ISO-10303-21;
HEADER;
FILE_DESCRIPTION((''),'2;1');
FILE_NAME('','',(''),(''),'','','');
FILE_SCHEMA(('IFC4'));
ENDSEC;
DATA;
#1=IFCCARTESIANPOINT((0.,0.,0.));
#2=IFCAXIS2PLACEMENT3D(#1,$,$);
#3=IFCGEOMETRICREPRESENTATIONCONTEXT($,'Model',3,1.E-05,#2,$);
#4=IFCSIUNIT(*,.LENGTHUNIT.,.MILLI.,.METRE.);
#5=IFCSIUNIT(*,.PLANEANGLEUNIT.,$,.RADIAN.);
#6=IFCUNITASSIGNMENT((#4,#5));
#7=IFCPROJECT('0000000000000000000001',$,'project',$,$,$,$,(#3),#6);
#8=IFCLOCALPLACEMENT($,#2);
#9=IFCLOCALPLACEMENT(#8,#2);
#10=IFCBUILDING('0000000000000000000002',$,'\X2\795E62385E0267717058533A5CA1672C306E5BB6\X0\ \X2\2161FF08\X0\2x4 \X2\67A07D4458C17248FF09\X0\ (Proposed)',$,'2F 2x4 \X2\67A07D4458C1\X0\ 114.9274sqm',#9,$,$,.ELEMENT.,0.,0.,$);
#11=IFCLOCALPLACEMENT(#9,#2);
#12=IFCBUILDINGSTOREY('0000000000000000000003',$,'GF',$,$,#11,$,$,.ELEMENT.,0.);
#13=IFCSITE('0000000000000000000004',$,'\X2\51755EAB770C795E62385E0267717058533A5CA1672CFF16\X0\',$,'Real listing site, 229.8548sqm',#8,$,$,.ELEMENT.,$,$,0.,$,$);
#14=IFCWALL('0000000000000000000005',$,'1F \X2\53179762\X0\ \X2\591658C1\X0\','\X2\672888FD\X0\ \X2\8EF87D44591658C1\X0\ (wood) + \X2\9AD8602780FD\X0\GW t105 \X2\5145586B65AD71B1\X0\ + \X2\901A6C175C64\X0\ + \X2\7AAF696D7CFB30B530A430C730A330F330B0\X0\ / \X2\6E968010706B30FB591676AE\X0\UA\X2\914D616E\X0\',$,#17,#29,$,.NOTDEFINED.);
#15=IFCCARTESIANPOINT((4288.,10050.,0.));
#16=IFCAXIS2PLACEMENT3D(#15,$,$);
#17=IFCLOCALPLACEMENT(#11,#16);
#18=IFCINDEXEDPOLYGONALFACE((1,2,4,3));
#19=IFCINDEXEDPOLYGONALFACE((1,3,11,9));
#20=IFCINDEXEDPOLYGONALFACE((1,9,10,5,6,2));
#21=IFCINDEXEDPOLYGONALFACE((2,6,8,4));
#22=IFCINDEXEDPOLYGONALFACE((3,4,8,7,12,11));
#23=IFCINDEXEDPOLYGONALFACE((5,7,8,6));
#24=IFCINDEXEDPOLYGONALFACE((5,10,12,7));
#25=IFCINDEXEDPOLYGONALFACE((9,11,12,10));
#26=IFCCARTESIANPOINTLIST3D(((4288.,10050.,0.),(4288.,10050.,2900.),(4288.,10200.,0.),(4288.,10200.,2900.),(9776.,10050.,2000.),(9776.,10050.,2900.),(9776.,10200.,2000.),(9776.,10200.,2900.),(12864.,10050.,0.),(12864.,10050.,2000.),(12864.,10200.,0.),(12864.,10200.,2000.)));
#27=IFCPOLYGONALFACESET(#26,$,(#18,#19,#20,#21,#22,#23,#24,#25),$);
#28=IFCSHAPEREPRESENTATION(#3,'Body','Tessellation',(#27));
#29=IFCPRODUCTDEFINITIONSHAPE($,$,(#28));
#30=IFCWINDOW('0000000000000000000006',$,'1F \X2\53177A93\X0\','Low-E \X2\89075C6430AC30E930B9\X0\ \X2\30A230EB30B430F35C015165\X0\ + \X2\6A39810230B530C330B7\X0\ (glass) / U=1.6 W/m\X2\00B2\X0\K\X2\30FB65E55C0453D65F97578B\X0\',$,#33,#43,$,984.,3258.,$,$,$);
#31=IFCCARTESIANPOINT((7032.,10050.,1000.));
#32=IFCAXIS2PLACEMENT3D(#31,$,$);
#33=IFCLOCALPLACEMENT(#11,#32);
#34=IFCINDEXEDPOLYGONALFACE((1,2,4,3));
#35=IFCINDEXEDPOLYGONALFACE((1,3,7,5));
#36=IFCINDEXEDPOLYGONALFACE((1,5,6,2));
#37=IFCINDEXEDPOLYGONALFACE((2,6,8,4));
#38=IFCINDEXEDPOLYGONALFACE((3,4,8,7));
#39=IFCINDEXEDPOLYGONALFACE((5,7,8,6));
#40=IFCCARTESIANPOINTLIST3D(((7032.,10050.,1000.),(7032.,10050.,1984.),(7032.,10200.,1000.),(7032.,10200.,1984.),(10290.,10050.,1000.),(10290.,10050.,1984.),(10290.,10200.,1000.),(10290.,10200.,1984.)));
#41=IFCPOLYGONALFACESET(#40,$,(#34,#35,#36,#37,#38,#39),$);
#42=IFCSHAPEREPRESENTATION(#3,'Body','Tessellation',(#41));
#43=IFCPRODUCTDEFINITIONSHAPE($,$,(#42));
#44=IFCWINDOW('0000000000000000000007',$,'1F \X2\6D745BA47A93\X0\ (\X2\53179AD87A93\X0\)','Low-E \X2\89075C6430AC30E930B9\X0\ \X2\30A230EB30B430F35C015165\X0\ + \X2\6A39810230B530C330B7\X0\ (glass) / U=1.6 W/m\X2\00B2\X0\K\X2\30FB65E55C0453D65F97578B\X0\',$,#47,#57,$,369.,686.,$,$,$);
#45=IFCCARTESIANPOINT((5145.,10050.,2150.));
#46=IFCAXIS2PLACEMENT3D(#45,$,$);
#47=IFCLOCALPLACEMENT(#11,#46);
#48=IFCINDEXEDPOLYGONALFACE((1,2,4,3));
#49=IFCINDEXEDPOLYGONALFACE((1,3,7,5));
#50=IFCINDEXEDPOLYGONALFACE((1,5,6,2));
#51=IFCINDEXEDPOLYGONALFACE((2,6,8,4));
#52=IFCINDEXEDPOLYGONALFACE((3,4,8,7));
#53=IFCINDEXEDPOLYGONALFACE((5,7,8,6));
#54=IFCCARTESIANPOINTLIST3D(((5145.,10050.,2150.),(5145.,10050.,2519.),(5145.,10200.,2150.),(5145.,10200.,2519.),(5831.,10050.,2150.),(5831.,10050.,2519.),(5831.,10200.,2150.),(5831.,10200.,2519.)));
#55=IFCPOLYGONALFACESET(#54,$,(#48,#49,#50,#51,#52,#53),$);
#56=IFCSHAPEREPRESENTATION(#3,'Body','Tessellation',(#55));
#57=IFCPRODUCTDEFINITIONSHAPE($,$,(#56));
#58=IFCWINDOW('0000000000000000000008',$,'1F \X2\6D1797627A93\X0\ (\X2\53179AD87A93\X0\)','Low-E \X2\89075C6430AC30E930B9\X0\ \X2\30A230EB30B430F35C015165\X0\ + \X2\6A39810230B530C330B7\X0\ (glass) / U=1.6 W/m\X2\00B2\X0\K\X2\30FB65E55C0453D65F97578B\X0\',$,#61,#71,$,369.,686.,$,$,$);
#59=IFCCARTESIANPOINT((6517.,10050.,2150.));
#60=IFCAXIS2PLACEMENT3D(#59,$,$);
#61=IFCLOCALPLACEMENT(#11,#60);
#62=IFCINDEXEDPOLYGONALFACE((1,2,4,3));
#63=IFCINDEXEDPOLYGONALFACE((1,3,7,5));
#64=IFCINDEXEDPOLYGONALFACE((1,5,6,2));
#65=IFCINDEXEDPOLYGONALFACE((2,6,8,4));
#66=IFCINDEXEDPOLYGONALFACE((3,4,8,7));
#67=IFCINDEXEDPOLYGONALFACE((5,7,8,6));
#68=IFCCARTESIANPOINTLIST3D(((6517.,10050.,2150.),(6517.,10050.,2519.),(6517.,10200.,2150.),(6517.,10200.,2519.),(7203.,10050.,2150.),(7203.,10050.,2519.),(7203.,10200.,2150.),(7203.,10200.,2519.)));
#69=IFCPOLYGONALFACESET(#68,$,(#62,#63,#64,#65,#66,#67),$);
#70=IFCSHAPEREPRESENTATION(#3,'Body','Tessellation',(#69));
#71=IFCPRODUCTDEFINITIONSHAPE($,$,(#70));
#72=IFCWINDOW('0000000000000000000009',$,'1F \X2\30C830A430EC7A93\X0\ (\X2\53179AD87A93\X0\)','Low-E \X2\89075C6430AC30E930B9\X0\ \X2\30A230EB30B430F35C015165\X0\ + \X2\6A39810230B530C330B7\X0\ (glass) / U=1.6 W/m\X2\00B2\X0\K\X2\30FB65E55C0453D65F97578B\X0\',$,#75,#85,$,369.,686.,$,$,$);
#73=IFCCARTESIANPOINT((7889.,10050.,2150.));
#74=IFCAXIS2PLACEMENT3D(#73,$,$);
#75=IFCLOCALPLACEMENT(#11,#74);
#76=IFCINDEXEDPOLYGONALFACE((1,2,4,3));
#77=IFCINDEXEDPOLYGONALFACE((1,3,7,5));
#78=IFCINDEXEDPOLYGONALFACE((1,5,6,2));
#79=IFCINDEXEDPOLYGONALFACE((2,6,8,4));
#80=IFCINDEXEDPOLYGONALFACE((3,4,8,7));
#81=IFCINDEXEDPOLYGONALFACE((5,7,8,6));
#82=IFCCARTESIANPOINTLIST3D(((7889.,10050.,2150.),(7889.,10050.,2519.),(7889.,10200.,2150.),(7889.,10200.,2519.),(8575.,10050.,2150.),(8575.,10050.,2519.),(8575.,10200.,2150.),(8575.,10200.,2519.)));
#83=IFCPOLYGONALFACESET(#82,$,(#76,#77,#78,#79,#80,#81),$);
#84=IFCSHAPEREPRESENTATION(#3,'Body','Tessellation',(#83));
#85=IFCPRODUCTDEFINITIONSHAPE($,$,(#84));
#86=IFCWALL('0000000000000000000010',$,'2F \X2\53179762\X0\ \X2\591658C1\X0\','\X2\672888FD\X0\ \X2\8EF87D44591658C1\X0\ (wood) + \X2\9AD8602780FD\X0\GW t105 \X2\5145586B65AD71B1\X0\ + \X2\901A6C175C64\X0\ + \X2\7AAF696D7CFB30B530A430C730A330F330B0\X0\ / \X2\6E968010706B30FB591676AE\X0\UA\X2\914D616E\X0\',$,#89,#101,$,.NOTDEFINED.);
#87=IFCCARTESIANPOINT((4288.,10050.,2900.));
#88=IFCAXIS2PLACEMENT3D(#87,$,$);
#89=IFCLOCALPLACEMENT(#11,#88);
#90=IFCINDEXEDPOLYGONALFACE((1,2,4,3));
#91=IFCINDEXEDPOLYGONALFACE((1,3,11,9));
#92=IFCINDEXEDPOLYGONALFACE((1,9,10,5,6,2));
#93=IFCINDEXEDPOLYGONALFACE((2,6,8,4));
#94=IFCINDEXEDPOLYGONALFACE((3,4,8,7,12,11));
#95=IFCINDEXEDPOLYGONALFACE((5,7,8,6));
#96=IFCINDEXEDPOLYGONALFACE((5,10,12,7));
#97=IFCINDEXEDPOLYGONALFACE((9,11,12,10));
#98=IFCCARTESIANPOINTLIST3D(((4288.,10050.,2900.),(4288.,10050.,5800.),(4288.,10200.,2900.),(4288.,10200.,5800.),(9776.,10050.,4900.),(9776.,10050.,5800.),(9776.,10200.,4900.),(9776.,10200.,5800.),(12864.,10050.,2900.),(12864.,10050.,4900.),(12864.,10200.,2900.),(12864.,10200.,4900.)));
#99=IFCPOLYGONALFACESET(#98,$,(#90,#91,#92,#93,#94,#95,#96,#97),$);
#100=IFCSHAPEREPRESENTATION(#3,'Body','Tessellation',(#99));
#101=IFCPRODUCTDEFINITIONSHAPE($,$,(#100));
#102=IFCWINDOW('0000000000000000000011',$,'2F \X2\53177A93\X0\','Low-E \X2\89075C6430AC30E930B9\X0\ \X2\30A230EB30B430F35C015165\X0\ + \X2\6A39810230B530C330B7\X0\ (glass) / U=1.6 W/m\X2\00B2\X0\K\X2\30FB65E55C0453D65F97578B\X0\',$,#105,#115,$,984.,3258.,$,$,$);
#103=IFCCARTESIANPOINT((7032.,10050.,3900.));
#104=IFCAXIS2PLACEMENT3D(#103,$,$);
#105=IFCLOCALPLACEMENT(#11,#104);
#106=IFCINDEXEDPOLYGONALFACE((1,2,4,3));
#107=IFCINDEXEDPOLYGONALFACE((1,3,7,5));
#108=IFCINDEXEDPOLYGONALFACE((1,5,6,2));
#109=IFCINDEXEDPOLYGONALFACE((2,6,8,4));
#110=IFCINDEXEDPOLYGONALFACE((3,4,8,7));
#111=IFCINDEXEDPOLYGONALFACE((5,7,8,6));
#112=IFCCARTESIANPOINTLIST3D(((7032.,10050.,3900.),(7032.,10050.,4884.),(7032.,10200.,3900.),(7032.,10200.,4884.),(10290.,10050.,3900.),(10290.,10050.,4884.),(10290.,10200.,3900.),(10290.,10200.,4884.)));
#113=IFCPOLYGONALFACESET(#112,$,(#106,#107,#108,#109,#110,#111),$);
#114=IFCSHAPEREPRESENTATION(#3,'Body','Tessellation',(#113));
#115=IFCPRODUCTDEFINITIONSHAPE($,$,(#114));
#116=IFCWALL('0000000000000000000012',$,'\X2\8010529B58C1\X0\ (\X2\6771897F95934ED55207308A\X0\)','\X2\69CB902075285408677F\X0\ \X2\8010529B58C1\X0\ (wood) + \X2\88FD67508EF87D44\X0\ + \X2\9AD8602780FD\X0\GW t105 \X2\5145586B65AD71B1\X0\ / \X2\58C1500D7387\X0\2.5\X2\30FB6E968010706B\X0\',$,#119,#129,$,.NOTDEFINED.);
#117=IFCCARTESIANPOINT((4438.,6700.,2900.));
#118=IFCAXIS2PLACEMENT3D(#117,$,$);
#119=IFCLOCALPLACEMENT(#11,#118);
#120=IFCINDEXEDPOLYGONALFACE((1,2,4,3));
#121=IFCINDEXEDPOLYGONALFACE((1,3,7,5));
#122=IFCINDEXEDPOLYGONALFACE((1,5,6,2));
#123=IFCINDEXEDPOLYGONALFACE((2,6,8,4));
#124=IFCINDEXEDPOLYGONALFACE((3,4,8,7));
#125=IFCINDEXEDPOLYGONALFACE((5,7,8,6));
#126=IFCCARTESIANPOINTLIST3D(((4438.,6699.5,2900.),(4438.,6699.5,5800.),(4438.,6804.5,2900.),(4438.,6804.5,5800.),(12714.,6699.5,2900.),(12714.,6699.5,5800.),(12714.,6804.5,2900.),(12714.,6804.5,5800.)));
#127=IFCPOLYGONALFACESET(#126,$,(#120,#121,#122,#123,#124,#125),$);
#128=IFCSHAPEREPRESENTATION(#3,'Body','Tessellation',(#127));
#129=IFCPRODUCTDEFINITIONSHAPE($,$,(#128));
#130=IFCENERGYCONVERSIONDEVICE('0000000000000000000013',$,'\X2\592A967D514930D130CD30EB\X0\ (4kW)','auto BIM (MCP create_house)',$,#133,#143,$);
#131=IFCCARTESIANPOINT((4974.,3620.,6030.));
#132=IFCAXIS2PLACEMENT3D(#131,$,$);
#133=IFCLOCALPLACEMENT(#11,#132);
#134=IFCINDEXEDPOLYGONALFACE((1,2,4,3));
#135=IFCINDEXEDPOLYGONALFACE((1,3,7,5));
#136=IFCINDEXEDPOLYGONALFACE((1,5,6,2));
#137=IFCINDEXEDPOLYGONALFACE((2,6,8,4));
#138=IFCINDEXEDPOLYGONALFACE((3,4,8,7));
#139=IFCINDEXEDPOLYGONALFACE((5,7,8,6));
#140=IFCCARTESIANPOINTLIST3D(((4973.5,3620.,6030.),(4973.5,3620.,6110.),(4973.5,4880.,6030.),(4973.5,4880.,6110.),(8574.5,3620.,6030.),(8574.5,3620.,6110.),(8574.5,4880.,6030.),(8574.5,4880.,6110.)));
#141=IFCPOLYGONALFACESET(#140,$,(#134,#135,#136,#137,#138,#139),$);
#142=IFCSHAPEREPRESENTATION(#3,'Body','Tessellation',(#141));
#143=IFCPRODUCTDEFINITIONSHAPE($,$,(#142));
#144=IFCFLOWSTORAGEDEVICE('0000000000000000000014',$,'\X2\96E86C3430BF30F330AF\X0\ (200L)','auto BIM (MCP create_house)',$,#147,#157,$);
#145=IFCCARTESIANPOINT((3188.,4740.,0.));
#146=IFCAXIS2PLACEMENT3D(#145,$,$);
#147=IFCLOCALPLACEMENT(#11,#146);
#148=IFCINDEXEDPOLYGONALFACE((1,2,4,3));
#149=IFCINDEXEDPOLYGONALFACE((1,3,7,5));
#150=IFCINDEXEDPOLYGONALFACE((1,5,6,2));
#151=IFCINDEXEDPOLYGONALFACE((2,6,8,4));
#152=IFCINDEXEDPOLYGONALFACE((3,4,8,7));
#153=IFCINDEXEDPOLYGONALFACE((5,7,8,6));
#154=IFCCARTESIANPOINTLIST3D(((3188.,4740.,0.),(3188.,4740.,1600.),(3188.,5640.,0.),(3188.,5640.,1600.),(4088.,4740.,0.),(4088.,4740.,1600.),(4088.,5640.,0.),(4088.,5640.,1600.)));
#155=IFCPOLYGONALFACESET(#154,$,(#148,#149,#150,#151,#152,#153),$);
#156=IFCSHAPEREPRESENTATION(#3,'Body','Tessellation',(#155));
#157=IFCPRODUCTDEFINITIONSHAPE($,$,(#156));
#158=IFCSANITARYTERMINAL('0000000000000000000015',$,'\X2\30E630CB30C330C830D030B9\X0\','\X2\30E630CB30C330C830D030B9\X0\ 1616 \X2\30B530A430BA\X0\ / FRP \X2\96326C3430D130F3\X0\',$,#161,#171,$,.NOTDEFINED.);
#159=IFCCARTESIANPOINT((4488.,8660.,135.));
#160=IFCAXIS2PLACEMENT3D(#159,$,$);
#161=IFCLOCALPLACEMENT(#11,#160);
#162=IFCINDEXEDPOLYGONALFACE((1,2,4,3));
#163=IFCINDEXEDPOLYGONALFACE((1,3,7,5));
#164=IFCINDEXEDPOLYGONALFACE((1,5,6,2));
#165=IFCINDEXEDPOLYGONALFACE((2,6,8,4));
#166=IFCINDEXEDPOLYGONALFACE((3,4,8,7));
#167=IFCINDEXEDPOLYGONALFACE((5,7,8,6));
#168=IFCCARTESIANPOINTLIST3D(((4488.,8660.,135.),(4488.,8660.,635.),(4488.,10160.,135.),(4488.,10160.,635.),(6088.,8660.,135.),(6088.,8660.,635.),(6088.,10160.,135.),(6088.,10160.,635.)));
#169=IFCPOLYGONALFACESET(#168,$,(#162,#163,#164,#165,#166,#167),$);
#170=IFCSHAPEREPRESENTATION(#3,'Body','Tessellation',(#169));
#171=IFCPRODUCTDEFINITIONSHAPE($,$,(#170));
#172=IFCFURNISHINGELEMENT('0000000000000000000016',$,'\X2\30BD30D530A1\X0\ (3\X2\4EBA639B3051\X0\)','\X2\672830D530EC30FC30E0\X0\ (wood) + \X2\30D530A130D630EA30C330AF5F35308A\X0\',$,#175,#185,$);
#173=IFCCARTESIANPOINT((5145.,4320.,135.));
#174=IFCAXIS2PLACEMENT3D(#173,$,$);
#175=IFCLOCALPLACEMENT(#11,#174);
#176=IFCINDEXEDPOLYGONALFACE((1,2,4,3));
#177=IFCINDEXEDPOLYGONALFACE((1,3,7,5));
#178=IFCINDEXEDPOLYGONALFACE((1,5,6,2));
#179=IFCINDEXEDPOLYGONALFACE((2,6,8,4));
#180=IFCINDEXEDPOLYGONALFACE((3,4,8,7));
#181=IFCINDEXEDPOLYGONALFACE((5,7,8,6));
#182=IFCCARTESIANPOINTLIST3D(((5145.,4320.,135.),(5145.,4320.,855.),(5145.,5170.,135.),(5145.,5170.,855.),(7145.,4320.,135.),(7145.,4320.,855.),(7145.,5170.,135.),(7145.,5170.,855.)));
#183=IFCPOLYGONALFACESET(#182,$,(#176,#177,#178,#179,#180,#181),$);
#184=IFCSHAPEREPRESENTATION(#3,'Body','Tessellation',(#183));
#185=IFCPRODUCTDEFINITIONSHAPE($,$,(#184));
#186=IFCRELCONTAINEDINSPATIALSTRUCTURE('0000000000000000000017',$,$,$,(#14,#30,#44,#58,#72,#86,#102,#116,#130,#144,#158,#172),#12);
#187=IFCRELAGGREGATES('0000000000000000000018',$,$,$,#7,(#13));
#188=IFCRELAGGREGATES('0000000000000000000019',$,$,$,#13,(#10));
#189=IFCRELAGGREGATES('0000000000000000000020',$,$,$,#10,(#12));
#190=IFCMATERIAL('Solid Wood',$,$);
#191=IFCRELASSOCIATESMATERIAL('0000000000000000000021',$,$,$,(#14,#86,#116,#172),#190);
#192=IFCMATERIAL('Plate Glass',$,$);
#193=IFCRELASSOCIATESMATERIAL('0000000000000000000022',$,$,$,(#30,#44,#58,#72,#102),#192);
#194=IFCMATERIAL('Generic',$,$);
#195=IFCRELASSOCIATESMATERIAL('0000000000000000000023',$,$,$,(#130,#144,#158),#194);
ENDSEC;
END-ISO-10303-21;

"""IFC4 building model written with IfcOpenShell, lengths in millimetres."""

from ifc_helpers import new_model, si_unit, frame, frame_2d, origin, place, context, project, spatial, rectangle, extrude, material, element, fill, save


model = new_model("IFC4")

# Units and contexts
model_context = context("Model", 3, precision=1e-05, world=origin())
ifc_project = project(units=[si_unit("LENGTHUNIT", "METRE", prefix="MILLI"), si_unit("PLANEANGLEUNIT", "RADIAN")], contexts=[model_context])

# Site, building, storey
site_placement = place(None, origin())
site = spatial("IfcSite", under=ifc_project, at=site_placement, Name="兵庫県神戸市東灘区岡本６", ObjectType="Real listing site, 229.8548sqm", CompositionType="ELEMENT", RefElevation=0.0)
building_placement = place(site_placement, origin())
building = spatial("IfcBuilding", under=site, at=building_placement, Name="神戸市東灘区岡本の家 Ⅱ（2x4 枠組壁版） (Proposed)", ObjectType="2F 2x4 枠組壁 114.9274sqm", CompositionType="ELEMENT", ElevationOfRefHeight=0.0, ElevationOfTerrain=0.0)
storey_placement = place(building_placement, origin())
storey = spatial("IfcBuildingStorey", under=building, at=storey_placement, Name="GF", CompositionType="ELEMENT", Elevation=0.0)

# Wall, openings, windows
ifc_material_1 = material(Name="Solid Wood")
wall_1_placement = place(storey_placement, frame((4288.0, 10050.0, 0.0)))
wall_1 = element("IfcWall", 1, at=wall_1_placement, inside=storey, material=ifc_material_1, Name="1F 北面 外壁", Description="木製 軸組外壁 (wood) + 高性能GW t105 充填断熱 + 通気層 + 窯業系サイディング / 準耐火・外皮UA配慮", PredefinedType="NOTDEFINED", context=model_context, shape_type="SweptSolid", body=[
    extrude(rectangle(XDim=8576.0, YDim=150.0, at=frame_2d((4288.0, 75.0))), frame((4288.0, 10050.0, 0.0)), (0.0, 0.0, 1.0), 2900.0),
])
opening_1_placement = place(storey_placement, frame((7032.0, 10050.0, 1000.0)))
opening_1 = element("IfcOpeningElement", 2, at=opening_1_placement, cuts=wall_1, PredefinedType="NOTDEFINED", context=model_context, shape_type="SweptSolid", body=[
    extrude(rectangle(XDim=3258.0, YDim=150.0, at=frame_2d((1629.0, 75.0))), frame((7032.0, 10050.0, 1000.0)), (0.0, 0.0, 1.0), 984.0),
])
opening_2_placement = place(storey_placement, frame((5145.0, 10050.0, 2150.0)))
opening_2 = element("IfcOpeningElement", 3, at=opening_2_placement, cuts=wall_1, PredefinedType="NOTDEFINED", context=model_context, shape_type="SweptSolid", body=[
    extrude(rectangle(XDim=686.0, YDim=150.0, at=frame_2d((343.0, 75.0))), frame((5145.0, 10050.0, 2150.0)), (0.0, 0.0, 1.0), 369.0),
])
opening_3_placement = place(storey_placement, frame((6517.0, 10050.0, 2150.0)))
opening_3 = element("IfcOpeningElement", 4, at=opening_3_placement, cuts=wall_1, PredefinedType="NOTDEFINED", context=model_context, shape_type="SweptSolid", body=[
    extrude(rectangle(XDim=686.0, YDim=150.0, at=frame_2d((343.0, 75.0))), frame((6517.0, 10050.0, 2150.0)), (0.0, 0.0, 1.0), 369.0),
])
opening_4_placement = place(storey_placement, frame((7889.0, 10050.0, 2150.0)))
opening_4 = element("IfcOpeningElement", 5, at=opening_4_placement, cuts=wall_1, PredefinedType="NOTDEFINED", context=model_context, shape_type="SweptSolid", body=[
    extrude(rectangle(XDim=686.0, YDim=150.0, at=frame_2d((343.0, 75.0))), frame((7889.0, 10050.0, 2150.0)), (0.0, 0.0, 1.0), 369.0),
])
ifc_material_2 = material(Name="Plate Glass")
window_1_placement = place(storey_placement, frame((7032.0, 10050.0, 1000.0)))
window_1 = element("IfcWindow", 6, at=window_1_placement, inside=storey, material=ifc_material_2, Name="1F 北窓", Description="Low-E 複層ガラス アルゴン封入 + 樹脂サッシ (glass) / U=1.6 W/m²K・日射取得型", OverallHeight=984.0, OverallWidth=3258.0, context=model_context, shape_type="SweptSolid", body=[
    extrude(rectangle(XDim=3258.0, YDim=150.0, at=frame_2d((1629.0, 75.0))), frame((7032.0, 10050.0, 1000.0)), (0.0, 0.0, 1.0), 984.0),
])
fill(opening_1, window_1)
window_2_placement = place(storey_placement, frame((5145.0, 10050.0, 2150.0)))
window_2 = element("IfcWindow", 7, at=window_2_placement, inside=storey, material=ifc_material_2, Name="1F 浴室窓 (北高窓)", Description="Low-E 複層ガラス アルゴン封入 + 樹脂サッシ (glass) / U=1.6 W/m²K・日射取得型", OverallHeight=369.0, OverallWidth=686.0, context=model_context, shape_type="SweptSolid", body=[
    extrude(rectangle(XDim=686.0, YDim=150.0, at=frame_2d((343.0, 75.0))), frame((5145.0, 10050.0, 2150.0)), (0.0, 0.0, 1.0), 369.0),
])
fill(opening_2, window_2)
window_3_placement = place(storey_placement, frame((6517.0, 10050.0, 2150.0)))
window_3 = element("IfcWindow", 8, at=window_3_placement, inside=storey, material=ifc_material_2, Name="1F 洗面窓 (北高窓)", Description="Low-E 複層ガラス アルゴン封入 + 樹脂サッシ (glass) / U=1.6 W/m²K・日射取得型", OverallHeight=369.0, OverallWidth=686.0, context=model_context, shape_type="SweptSolid", body=[
    extrude(rectangle(XDim=686.0, YDim=150.0, at=frame_2d((343.0, 75.0))), frame((6517.0, 10050.0, 2150.0)), (0.0, 0.0, 1.0), 369.0),
])
fill(opening_3, window_3)
window_4_placement = place(storey_placement, frame((7889.0, 10050.0, 2150.0)))
window_4 = element("IfcWindow", 9, at=window_4_placement, inside=storey, material=ifc_material_2, Name="1F トイレ窓 (北高窓)", Description="Low-E 複層ガラス アルゴン封入 + 樹脂サッシ (glass) / U=1.6 W/m²K・日射取得型", OverallHeight=369.0, OverallWidth=686.0, context=model_context, shape_type="SweptSolid", body=[
    extrude(rectangle(XDim=686.0, YDim=150.0, at=frame_2d((343.0, 75.0))), frame((7889.0, 10050.0, 2150.0)), (0.0, 0.0, 1.0), 369.0),
])
fill(opening_4, window_4)

# Wall, opening, window
wall_2_placement = place(storey_placement, frame((4288.0, 10050.0, 2900.0)))
wall_2 = element("IfcWall", 10, at=wall_2_placement, inside=storey, material=ifc_material_1, Name="2F 北面 外壁", Description="木製 軸組外壁 (wood) + 高性能GW t105 充填断熱 + 通気層 + 窯業系サイディング / 準耐火・外皮UA配慮", PredefinedType="NOTDEFINED", context=model_context, shape_type="SweptSolid", body=[
    extrude(rectangle(XDim=8576.0, YDim=150.0, at=frame_2d((4288.0, 75.0))), frame((4288.0, 10050.0, 2900.0)), (0.0, 0.0, 1.0), 2900.0),
])
opening_5_placement = place(storey_placement, frame((7032.0, 10050.0, 3900.0)))
opening_5 = element("IfcOpeningElement", 11, at=opening_5_placement, cuts=wall_2, PredefinedType="NOTDEFINED", context=model_context, shape_type="SweptSolid", body=[
    extrude(rectangle(XDim=3258.0, YDim=150.0, at=frame_2d((1629.0, 75.0))), frame((7032.0, 10050.0, 3900.0)), (0.0, 0.0, 1.0), 984.0),
])
window_5_placement = place(storey_placement, frame((7032.0, 10050.0, 3900.0)))
window_5 = element("IfcWindow", 12, at=window_5_placement, inside=storey, material=ifc_material_2, Name="2F 北窓", Description="Low-E 複層ガラス アルゴン封入 + 樹脂サッシ (glass) / U=1.6 W/m²K・日射取得型", OverallHeight=984.0, OverallWidth=3258.0, context=model_context, shape_type="SweptSolid", body=[
    extrude(rectangle(XDim=3258.0, YDim=150.0, at=frame_2d((1629.0, 75.0))), frame((7032.0, 10050.0, 3900.0)), (0.0, 0.0, 1.0), 984.0),
])
fill(opening_5, window_5)

# Wall
wall_3_placement = place(storey_placement, frame((4438.0, 6700.0, 2900.0)))
element("IfcWall", 13, at=wall_3_placement, inside=storey, material=ifc_material_1, Name="耐力壁 (東西間仕切り)", Description="構造用合板 耐力壁 (wood) + 製材軸組 + 高性能GW t105 充填断熱 / 壁倍率2.5・準耐火", PredefinedType="NOTDEFINED", context=model_context, shape_type="SweptSolid", body=[
    extrude(rectangle(XDim=8276.0, YDim=105.0, at=frame_2d((4138.0, 52.0))), frame((4438.0, 6700.0, 2900.0)), (0.0, 0.0, 1.0), 2900.0),
])

# Energy conversion device
ifc_material_3 = material(Name="Generic")
energy_conversion_device_placement = place(storey_placement, frame((4974.0, 3620.0, 6030.0)))
element("IfcEnergyConversionDevice", 14, at=energy_conversion_device_placement, inside=storey, material=ifc_material_3, Name="太陽光パネル (4kW)", Description="auto BIM (MCP create_house)", context=model_context, shape_type="SweptSolid", body=[
    extrude(rectangle(XDim=3601.0, YDim=1260.0, at=frame_2d((1800.0, 630.0))), frame((4974.0, 3620.0, 6030.0)), (0.0, 0.0, 1.0), 80.0),
])

# Flow storage device
flow_storage_device_placement = place(storey_placement, frame((3188.0, 4740.0, 0.0)))
element("IfcFlowStorageDevice", 15, at=flow_storage_device_placement, inside=storey, material=ifc_material_3, Name="雨水タンク (200L)", Description="auto BIM (MCP create_house)", context=model_context, shape_type="SweptSolid", body=[
    extrude(rectangle(XDim=900.0, YDim=900.0, at=frame_2d((450.0, 450.0))), frame((3188.0, 4740.0, 0.0)), (0.0, 0.0, 1.0), 1600.0),
])

# Sanitary terminal
sanitary_terminal_placement = place(storey_placement, frame((4488.0, 8660.0, 135.0)))
element("IfcSanitaryTerminal", 16, at=sanitary_terminal_placement, inside=storey, material=ifc_material_3, Name="ユニットバス", Description="ユニットバス 1616 サイズ / FRP 防水パン", PredefinedType="NOTDEFINED", context=model_context, shape_type="SweptSolid", body=[
    extrude(rectangle(XDim=1600.0, YDim=1500.0, at=frame_2d((800.0, 750.0))), frame((4488.0, 8660.0, 135.0)), (0.0, 0.0, 1.0), 500.0),
])

# Furnishing element
furnishing_1_placement = place(storey_placement, frame((5145.0, 4320.0, 135.0)))
element("IfcFurnishingElement", 17, at=furnishing_1_placement, inside=storey, material=ifc_material_1, Name="ソファ (3人掛け)", Description="木フレーム (wood) + ファブリック張り", context=model_context, shape_type="SweptSolid", body=[
    extrude(rectangle(XDim=2000.0, YDim=850.0, at=frame_2d((1000.0, 425.0))), frame((5145.0, 4320.0, 135.0)), (0.0, 0.0, 1.0), 720.0),
])

save(model, "model.ifc")
